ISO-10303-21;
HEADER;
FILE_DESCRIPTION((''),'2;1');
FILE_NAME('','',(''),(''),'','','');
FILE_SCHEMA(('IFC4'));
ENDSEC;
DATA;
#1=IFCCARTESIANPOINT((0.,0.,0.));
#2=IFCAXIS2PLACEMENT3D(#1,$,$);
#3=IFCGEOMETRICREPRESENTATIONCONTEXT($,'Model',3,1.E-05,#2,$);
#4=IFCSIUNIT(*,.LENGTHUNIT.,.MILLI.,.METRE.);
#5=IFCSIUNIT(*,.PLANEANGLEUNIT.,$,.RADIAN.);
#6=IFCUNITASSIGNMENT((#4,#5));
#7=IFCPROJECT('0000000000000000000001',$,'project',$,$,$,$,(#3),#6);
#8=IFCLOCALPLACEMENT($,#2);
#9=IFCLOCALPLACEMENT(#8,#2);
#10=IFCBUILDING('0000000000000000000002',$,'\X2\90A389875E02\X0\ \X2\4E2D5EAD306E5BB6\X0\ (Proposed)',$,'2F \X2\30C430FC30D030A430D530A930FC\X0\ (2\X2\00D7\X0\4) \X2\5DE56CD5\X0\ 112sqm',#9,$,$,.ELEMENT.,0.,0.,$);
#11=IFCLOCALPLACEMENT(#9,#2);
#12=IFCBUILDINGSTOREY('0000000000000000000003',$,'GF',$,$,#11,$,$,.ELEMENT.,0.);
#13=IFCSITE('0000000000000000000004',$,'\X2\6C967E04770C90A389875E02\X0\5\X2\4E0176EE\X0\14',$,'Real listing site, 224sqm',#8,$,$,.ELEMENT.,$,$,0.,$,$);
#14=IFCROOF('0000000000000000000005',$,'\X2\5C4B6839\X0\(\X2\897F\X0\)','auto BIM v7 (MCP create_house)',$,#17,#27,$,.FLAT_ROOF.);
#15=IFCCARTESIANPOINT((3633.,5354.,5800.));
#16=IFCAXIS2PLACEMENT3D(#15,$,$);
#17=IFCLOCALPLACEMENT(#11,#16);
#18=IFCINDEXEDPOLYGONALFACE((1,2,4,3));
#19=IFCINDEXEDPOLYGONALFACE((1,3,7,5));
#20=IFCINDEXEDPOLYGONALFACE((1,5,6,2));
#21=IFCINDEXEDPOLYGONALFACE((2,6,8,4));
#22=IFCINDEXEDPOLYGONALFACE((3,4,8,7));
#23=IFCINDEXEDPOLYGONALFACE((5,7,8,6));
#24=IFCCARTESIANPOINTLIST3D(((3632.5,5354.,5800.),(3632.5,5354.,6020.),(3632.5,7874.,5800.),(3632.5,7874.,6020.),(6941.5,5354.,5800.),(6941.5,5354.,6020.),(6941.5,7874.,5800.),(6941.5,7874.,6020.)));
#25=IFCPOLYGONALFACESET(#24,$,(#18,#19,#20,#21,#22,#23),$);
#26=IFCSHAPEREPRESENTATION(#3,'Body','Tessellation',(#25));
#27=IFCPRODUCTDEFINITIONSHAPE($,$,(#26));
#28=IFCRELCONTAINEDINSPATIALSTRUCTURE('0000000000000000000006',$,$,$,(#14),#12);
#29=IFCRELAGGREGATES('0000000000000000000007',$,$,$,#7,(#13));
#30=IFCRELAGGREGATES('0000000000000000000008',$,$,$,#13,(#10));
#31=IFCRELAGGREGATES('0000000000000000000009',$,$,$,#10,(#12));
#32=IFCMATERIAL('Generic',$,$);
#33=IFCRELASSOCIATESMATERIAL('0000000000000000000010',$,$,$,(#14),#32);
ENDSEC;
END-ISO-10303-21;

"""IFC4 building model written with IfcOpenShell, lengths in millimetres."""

from ifc_helpers import new_model, si_unit, frame, frame_2d, origin, place, context, project, spatial, rectangle, extrude, material, element, save


model = new_model("IFC4")

# Units and contexts
model_context = context("Model", 3, precision=1e-05, world=origin())
ifc_project = project(units=[si_unit("LENGTHUNIT", "METRE", prefix="MILLI"), si_unit("PLANEANGLEUNIT", "RADIAN")], contexts=[model_context])

# Site, building, storey
site_placement = place(None, origin())
site = spatial("IfcSite", under=ifc_project, at=site_placement, Name="沖縄県那覇市5丁目14", ObjectType="Real listing site, 224sqm", CompositionType="ELEMENT", RefElevation=0.0)
building_placement = place(site_placement, origin())
building = spatial("IfcBuilding", under=site, at=building_placement, Name="那覇市 中庭の家 (Proposed)", ObjectType="2F ツーバイフォー (2×4) 工法 112sqm", CompositionType="ELEMENT", ElevationOfRefHeight=0.0, ElevationOfTerrain=0.0)
storey_placement = place(building_placement, origin())
storey = spatial("IfcBuildingStorey", under=building, at=storey_placement, Name="GF", CompositionType="ELEMENT", Elevation=0.0)

# Shared definitions
ifc_material = material(Name="Generic")

# Roof
roof_1_placement = place(storey_placement, frame((3633.0, 5354.0, 5800.0)))
element("IfcRoof", 1, at=roof_1_placement, inside=storey, material=ifc_material, Name="屋根(西)", Description="auto BIM v7 (MCP create_house)", PredefinedType="FLAT_ROOF", context=model_context, shape_type="SweptSolid", body=[
    extrude(rectangle(XDim=3309.0, YDim=2520.0, at=frame_2d((1654.0, 1260.0))), frame((3633.0, 5354.0, 5800.0)), (0.0, 0.0, 1.0), 220.0),
])

save(model, "model.ifc")
